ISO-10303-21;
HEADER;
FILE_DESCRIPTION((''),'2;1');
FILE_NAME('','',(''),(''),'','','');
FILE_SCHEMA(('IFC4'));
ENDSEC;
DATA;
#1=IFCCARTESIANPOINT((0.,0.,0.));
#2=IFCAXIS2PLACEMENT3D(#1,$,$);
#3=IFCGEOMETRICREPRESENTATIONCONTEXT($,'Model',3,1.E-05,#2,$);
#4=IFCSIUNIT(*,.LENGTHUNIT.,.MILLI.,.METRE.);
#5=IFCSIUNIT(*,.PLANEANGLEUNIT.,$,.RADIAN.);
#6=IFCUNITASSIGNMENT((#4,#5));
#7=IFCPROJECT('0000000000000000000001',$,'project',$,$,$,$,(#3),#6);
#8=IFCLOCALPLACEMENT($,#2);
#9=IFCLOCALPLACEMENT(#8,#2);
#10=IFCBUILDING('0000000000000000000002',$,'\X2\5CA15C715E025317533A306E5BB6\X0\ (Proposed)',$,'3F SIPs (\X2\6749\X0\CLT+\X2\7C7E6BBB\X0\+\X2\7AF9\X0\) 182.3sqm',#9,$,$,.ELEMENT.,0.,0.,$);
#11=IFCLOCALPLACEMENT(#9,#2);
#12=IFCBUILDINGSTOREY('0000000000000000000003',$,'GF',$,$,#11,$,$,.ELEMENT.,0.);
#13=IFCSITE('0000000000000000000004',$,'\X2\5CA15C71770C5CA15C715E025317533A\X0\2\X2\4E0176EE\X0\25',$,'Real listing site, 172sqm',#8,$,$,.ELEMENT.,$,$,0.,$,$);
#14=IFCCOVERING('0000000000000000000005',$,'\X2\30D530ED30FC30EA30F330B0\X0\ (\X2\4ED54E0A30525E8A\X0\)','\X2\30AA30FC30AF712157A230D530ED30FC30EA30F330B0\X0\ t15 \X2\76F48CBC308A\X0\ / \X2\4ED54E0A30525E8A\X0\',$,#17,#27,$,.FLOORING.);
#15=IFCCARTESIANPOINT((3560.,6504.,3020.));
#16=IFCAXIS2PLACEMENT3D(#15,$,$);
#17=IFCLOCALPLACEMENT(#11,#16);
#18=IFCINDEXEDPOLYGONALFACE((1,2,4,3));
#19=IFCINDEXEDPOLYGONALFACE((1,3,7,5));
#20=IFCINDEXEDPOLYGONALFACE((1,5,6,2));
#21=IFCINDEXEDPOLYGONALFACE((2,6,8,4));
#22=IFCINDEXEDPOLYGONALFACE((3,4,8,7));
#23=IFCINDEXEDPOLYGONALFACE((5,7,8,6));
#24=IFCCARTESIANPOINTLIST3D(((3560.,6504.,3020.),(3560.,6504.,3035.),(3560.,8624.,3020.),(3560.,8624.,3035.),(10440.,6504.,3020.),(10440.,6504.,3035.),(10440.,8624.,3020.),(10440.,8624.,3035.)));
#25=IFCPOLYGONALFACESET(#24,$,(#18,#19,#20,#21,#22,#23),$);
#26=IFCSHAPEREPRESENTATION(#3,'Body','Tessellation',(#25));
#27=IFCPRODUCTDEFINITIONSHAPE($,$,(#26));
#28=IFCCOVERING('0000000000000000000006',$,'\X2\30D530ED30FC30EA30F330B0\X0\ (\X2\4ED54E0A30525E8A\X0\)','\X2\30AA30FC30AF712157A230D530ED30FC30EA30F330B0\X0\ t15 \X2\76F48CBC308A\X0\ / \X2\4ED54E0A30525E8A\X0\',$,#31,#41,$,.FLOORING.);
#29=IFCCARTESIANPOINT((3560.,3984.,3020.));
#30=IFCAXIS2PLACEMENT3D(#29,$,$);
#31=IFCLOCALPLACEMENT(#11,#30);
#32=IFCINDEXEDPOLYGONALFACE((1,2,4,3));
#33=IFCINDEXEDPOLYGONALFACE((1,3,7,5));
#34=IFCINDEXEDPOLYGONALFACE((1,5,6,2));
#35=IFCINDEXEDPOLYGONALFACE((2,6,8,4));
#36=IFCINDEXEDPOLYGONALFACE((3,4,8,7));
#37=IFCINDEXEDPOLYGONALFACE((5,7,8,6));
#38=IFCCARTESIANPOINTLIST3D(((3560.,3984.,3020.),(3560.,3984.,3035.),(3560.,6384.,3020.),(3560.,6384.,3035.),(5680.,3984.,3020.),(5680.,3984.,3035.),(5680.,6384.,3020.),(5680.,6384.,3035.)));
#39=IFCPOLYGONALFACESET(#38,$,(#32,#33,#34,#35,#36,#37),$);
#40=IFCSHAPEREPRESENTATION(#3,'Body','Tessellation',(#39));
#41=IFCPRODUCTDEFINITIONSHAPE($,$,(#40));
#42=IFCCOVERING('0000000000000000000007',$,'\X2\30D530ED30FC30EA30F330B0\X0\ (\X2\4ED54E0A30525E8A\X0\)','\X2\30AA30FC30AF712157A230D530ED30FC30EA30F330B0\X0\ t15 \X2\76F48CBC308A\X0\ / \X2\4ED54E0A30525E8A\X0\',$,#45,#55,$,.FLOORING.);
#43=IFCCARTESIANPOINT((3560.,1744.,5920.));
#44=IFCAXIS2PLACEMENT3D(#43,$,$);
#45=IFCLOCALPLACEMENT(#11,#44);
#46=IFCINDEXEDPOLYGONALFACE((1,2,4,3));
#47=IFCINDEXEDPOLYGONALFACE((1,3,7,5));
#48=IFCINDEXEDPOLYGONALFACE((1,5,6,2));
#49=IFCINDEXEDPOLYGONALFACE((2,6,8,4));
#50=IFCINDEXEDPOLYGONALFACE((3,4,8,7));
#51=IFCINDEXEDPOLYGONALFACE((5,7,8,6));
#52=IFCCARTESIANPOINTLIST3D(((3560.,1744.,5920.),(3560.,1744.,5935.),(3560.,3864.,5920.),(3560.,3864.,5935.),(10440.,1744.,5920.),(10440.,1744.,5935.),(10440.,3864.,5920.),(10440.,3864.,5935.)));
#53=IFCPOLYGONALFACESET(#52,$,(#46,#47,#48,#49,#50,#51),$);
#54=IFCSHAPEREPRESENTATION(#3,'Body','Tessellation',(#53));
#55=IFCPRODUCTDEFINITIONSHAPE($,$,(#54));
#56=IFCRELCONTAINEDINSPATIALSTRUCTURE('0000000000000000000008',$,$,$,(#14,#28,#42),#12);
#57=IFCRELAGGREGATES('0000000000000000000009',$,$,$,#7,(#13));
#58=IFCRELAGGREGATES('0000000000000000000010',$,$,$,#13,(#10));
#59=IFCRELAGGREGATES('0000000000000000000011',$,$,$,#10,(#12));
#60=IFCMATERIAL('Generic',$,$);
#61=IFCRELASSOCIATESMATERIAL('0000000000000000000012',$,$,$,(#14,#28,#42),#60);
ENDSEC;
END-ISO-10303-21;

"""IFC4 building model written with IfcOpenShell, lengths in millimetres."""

from ifc_helpers import new_model, si_unit, frame, frame_2d, origin, place, context, project, spatial, rectangle, extrude, material, element, save


model = new_model("IFC4")

# Units and contexts
model_context = context("Model", 3, precision=1e-05, world=origin())
ifc_project = project(units=[si_unit("LENGTHUNIT", "METRE", prefix="MILLI"), si_unit("PLANEANGLEUNIT", "RADIAN")], contexts=[model_context])

# Site, building, storey
site_placement = place(None, origin())
site = spatial("IfcSite", under=ifc_project, at=site_placement, Name="岡山県岡山市北区2丁目25", ObjectType="Real listing site, 172sqm", CompositionType="ELEMENT", RefElevation=0.0)
building_placement = place(site_placement, origin())
building = spatial("IfcBuilding", under=site, at=building_placement, Name="岡山市北区の家 (Proposed)", ObjectType="3F SIPs (杉CLT+籾殻+竹) 182.3sqm", CompositionType="ELEMENT", ElevationOfRefHeight=0.0, ElevationOfTerrain=0.0)
storey_placement = place(building_placement, origin())
storey = spatial("IfcBuildingStorey", under=building, at=storey_placement, Name="GF", CompositionType="ELEMENT", Elevation=0.0)

# Shared definitions
ifc_material_1 = material(Name="Generic")

# Coverings
covering_1_placement = place(storey_placement, frame((3560.0, 6504.0, 3020.0)))
element("IfcCovering", 1, at=covering_1_placement, inside=storey, material=ifc_material_1, Name="フローリング (仕上げ床)", Description="オーク無垢フローリング t15 直貼り / 仕上げ床", PredefinedType="FLOORING", context=model_context, shape_type="SweptSolid", body=[
    extrude(rectangle(XDim=6880.0, YDim=2120.0, at=frame_2d((3440.0, 1060.0))), frame((3560.0, 6504.0, 3020.0)), (0.0, 0.0, 1.0), 15.0),
])
covering_2_placement = place(storey_placement, frame((3560.0, 3984.0, 3020.0)))
element("IfcCovering", 2, at=covering_2_placement, inside=storey, material=ifc_material_1, Name="フローリング (仕上げ床)", Description="オーク無垢フローリング t15 直貼り / 仕上げ床", PredefinedType="FLOORING", context=model_context, shape_type="SweptSolid", body=[
    extrude(rectangle(XDim=2120.0, YDim=2400.0, at=frame_2d((1060.0, 1200.0))), frame((3560.0, 3984.0, 3020.0)), (0.0, 0.0, 1.0), 15.0),
])
covering_3_placement = place(storey_placement, frame((3560.0, 1744.0, 5920.0)))
element("IfcCovering", 3, at=covering_3_placement, inside=storey, material=ifc_material_1, Name="フローリング (仕上げ床)", Description="オーク無垢フローリング t15 直貼り / 仕上げ床", PredefinedType="FLOORING", context=model_context, shape_type="SweptSolid", body=[
    extrude(rectangle(XDim=6880.0, YDim=2120.0, at=frame_2d((3440.0, 1060.0))), frame((3560.0, 1744.0, 5920.0)), (0.0, 0.0, 1.0), 15.0),
])

save(model, "model.ifc")
